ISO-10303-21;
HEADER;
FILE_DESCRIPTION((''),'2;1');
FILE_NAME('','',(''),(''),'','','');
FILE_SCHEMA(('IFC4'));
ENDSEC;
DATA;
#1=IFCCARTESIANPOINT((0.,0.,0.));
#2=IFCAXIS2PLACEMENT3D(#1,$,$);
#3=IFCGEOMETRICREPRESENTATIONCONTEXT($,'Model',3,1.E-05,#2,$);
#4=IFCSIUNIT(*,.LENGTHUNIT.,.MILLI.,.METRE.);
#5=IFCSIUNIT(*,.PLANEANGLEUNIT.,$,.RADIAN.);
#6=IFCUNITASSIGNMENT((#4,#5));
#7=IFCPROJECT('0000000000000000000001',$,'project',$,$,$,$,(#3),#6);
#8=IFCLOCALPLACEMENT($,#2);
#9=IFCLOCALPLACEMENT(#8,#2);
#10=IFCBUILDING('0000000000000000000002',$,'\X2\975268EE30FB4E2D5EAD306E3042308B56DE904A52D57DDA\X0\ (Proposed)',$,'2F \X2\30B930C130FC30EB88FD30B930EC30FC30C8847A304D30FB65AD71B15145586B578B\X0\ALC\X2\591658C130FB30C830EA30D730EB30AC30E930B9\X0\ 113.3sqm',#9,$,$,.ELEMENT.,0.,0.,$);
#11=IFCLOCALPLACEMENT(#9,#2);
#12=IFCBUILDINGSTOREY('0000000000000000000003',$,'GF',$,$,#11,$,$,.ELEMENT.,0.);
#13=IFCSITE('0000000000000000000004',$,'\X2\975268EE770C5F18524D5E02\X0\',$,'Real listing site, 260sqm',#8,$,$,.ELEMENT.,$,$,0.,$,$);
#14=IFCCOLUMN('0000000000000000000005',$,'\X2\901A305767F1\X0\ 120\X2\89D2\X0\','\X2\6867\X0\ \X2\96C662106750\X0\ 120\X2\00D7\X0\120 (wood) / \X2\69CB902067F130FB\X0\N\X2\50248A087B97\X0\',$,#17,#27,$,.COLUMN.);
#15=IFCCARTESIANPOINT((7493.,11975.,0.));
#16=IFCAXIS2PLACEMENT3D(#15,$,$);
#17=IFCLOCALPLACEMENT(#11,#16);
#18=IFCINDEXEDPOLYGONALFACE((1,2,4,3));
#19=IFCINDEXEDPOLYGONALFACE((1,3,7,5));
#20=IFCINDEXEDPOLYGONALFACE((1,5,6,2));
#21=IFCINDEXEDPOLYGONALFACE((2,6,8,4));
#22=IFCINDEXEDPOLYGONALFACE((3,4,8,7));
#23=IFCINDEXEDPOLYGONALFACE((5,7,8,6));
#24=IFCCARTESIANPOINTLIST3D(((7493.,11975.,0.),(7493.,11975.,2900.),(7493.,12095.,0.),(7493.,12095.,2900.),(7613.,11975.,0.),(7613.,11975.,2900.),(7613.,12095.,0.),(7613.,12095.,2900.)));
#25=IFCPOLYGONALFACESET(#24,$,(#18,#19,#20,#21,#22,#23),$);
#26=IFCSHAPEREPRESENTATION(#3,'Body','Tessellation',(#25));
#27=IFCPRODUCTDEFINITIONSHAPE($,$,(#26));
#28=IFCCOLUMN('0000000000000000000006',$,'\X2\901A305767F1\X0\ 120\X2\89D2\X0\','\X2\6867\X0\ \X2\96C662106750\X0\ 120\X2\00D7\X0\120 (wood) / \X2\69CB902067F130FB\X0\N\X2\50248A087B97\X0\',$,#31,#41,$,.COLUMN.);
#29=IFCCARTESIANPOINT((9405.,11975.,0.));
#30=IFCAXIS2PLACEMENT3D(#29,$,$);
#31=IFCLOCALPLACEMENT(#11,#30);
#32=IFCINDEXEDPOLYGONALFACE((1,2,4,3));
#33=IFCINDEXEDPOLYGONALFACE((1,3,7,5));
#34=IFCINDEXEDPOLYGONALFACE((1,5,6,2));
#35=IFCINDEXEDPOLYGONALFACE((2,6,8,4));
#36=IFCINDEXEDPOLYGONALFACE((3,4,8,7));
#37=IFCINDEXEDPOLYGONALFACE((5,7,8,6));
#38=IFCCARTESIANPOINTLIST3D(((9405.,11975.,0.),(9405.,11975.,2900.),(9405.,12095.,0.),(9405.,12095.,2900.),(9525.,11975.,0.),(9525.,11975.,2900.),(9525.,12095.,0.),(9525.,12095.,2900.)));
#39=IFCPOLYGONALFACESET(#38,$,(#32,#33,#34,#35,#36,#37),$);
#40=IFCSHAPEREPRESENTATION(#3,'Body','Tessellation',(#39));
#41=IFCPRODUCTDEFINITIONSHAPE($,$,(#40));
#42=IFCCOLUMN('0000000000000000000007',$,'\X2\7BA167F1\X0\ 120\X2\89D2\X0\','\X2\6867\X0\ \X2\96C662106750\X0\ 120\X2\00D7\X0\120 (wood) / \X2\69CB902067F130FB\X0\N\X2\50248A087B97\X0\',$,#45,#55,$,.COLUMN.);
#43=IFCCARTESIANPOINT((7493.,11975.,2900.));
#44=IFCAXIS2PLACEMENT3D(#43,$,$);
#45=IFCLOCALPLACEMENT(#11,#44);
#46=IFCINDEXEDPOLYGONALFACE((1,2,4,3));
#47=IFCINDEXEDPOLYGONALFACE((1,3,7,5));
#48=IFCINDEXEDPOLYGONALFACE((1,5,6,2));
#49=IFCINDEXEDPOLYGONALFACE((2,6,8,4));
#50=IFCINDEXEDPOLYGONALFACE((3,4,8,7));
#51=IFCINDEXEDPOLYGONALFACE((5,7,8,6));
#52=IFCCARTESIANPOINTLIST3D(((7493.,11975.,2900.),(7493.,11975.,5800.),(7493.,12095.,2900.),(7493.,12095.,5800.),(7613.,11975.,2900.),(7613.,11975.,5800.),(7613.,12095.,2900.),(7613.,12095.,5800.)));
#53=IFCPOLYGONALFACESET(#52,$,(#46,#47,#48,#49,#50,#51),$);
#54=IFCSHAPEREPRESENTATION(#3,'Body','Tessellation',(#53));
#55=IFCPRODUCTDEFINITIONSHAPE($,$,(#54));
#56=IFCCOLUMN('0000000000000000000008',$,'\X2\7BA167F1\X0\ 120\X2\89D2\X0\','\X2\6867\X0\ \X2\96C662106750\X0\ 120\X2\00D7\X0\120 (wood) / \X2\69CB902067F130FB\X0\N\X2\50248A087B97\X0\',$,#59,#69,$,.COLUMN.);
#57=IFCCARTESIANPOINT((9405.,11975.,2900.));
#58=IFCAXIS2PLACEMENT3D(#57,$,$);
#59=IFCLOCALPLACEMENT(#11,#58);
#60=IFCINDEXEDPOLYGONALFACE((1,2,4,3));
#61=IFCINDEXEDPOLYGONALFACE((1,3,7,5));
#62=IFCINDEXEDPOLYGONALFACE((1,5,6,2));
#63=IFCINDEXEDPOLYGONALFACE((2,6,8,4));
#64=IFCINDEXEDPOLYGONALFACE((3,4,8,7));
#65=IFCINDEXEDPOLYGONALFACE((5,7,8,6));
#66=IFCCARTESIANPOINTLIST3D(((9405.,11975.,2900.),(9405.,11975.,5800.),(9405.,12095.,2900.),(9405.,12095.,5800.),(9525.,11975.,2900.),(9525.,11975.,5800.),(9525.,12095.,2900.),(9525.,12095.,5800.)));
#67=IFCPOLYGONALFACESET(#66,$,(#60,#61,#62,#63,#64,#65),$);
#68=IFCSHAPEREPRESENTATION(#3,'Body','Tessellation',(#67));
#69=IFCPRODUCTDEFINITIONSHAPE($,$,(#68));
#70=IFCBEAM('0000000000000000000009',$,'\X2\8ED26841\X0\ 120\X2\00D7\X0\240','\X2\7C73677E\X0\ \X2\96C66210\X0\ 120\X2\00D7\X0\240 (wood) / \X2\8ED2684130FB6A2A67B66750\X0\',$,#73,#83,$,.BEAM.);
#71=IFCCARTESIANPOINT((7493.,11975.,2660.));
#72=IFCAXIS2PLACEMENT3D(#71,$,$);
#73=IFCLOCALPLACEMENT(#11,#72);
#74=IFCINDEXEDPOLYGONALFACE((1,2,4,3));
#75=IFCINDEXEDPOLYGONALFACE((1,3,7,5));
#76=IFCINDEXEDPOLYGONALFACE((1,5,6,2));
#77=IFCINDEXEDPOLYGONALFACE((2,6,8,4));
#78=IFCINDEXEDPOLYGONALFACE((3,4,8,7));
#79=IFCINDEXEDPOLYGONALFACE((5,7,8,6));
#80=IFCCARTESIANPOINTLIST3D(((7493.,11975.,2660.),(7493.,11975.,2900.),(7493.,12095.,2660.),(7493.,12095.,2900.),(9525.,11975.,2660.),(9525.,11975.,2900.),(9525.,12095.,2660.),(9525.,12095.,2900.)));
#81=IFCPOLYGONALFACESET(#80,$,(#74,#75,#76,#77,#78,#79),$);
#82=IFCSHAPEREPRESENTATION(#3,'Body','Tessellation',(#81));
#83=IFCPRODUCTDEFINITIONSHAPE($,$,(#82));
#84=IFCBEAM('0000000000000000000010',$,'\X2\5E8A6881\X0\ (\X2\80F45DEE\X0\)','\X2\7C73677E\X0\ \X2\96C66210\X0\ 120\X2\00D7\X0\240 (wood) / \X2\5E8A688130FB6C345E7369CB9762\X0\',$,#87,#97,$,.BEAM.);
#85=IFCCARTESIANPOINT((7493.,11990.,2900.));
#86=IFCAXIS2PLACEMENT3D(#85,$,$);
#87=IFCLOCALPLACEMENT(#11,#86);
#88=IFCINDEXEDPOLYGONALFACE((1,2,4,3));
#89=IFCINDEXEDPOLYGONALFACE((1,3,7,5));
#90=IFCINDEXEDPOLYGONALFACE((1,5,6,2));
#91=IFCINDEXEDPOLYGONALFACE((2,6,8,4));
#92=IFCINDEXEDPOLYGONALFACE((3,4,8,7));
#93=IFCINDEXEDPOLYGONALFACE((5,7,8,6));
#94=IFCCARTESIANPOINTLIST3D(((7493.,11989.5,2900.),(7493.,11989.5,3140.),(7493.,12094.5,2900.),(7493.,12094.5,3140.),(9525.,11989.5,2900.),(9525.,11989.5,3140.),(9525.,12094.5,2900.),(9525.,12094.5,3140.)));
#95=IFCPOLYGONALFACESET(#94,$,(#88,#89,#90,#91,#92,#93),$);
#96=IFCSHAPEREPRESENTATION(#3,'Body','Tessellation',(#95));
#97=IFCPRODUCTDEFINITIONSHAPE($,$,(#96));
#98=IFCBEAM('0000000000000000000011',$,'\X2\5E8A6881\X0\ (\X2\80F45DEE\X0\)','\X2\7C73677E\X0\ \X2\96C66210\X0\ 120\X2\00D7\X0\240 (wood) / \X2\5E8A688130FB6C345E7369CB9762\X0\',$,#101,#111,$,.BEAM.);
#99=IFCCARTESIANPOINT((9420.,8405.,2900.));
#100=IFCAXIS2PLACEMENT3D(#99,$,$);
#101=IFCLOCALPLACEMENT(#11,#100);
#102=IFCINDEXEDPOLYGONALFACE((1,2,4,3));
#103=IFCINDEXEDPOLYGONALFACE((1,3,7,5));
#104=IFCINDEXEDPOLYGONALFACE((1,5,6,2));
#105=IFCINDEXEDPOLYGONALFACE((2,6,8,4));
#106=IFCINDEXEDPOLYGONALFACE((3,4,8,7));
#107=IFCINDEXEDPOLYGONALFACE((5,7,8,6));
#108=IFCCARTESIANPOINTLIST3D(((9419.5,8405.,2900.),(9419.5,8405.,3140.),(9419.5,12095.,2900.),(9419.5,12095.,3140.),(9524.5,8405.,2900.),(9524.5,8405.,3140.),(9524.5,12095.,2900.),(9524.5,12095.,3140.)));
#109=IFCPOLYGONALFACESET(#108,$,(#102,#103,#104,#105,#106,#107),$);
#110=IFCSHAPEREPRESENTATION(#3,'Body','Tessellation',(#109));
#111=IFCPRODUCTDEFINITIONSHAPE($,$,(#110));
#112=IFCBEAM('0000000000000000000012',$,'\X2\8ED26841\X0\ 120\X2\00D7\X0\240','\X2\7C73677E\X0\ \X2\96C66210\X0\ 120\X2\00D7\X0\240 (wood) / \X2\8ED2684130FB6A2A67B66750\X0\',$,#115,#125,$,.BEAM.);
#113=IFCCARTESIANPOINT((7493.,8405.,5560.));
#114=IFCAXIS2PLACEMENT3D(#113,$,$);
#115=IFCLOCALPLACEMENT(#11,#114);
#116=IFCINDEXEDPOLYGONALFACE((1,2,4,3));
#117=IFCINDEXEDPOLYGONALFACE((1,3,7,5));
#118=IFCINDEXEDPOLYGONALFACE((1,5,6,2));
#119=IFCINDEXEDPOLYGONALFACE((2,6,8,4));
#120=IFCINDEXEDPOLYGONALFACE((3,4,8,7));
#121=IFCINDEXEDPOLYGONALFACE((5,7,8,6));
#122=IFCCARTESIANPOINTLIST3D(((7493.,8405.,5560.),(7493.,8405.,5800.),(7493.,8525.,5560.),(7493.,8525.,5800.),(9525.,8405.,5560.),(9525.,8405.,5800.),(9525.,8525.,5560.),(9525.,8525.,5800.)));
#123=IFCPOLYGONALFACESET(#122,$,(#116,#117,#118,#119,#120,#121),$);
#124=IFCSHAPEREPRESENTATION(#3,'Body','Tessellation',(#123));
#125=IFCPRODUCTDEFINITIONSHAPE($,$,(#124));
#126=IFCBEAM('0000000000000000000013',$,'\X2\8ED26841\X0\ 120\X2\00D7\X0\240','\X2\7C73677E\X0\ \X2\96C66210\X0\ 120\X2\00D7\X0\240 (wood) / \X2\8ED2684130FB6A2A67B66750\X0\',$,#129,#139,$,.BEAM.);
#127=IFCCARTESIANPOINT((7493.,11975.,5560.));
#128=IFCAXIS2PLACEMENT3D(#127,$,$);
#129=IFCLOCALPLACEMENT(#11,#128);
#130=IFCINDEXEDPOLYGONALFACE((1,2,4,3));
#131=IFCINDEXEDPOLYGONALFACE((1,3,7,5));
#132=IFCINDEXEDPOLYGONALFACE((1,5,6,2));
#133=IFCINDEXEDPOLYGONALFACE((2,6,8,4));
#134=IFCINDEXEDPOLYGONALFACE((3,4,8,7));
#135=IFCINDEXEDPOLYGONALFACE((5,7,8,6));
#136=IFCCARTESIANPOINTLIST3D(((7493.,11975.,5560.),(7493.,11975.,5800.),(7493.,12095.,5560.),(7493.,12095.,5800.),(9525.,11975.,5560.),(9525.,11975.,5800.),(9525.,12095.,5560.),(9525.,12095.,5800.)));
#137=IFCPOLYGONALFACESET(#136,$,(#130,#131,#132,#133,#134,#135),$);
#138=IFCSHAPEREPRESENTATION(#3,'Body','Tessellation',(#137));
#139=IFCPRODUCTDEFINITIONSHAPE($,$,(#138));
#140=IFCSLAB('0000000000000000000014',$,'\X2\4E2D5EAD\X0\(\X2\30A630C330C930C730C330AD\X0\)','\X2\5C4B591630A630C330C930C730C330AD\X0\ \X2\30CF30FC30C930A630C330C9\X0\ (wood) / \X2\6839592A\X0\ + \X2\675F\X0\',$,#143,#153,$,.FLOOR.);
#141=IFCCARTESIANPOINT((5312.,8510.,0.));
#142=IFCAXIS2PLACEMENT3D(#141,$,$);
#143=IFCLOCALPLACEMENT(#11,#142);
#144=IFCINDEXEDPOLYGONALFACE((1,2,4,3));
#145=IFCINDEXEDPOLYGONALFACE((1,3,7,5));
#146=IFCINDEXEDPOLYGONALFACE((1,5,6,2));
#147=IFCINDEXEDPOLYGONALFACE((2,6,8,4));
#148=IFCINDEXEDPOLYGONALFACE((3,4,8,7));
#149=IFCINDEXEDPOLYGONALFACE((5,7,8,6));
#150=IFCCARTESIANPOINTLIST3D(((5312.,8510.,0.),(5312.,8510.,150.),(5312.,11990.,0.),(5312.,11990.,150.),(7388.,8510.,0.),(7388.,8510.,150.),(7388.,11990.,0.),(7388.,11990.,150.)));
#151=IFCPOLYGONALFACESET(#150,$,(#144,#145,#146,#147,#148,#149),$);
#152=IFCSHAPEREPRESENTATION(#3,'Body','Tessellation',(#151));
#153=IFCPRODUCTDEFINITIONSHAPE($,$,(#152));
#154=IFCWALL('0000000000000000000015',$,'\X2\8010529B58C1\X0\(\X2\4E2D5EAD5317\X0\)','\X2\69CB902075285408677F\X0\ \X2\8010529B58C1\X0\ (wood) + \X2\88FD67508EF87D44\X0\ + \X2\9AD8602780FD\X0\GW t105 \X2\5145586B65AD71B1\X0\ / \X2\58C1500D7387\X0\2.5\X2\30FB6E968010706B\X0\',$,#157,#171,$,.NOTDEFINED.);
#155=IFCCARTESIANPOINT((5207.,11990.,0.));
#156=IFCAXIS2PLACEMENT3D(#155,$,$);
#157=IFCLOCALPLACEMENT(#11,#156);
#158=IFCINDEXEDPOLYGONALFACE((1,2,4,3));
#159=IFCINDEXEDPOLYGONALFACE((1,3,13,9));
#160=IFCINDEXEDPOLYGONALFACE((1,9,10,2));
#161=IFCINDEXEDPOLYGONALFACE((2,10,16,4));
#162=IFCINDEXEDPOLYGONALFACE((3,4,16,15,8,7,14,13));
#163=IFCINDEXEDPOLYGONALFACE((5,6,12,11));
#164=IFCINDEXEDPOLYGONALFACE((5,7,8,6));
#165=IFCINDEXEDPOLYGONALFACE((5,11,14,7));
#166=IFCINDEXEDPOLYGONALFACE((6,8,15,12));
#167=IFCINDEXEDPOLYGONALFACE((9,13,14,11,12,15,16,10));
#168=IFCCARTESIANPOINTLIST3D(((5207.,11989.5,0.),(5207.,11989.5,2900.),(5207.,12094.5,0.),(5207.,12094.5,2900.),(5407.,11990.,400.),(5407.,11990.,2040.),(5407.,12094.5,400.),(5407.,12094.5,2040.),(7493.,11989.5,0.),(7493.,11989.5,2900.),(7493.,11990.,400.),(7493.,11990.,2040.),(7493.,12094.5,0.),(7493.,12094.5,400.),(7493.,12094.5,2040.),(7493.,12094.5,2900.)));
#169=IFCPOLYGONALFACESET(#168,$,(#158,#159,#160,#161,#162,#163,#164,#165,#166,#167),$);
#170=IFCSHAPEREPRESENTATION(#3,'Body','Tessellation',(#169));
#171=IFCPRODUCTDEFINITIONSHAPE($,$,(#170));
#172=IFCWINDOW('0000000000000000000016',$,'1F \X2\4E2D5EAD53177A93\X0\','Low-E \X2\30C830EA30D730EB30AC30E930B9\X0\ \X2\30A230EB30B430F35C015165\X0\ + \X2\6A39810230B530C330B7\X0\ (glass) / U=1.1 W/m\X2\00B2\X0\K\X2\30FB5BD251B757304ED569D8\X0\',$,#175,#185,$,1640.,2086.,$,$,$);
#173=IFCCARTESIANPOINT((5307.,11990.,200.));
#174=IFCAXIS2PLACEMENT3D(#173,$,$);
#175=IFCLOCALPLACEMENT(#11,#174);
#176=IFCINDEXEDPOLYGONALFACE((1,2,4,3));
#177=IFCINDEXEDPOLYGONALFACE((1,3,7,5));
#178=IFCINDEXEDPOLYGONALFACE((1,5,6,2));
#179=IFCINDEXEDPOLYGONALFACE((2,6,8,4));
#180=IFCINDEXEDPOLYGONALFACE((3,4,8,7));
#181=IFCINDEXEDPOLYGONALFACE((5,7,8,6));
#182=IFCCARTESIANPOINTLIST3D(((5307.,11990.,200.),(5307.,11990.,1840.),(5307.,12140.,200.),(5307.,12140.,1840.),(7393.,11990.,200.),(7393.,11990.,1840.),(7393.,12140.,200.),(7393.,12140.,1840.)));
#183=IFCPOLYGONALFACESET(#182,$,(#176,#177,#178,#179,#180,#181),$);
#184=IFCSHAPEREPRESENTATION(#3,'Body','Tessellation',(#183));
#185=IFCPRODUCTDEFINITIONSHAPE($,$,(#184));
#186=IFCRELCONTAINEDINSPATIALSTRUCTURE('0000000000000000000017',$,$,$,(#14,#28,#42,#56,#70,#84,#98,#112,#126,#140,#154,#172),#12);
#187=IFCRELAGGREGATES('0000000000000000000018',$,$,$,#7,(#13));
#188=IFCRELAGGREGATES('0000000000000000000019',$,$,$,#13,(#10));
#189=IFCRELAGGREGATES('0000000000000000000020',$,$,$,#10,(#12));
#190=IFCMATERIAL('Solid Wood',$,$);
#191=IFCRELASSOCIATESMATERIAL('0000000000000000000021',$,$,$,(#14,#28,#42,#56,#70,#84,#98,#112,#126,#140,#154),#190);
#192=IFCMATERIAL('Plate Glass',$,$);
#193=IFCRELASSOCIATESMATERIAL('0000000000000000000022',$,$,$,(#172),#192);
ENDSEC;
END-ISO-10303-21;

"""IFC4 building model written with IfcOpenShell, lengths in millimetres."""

from ifc_helpers import new_model, si_unit, frame, frame_2d, origin, place, context, project, spatial, rectangle, extrude, material, element, fill, save


model = new_model("IFC4")

# Units and contexts
model_context = context("Model", 3, precision=1e-05, world=origin())
ifc_project = project(units=[si_unit("LENGTHUNIT", "METRE", prefix="MILLI"), si_unit("PLANEANGLEUNIT", "RADIAN")], contexts=[model_context])

# Site, building, storey
site_placement = place(None, origin())
site = spatial("IfcSite", under=ifc_project, at=site_placement, Name="青森県弘前市", ObjectType="Real listing site, 260sqm", CompositionType="ELEMENT", RefElevation=0.0)
building_placement = place(site_placement, origin())
building = spatial("IfcBuilding", under=site, at=building_placement, Name="青森・中庭のある回遊動線 (Proposed)", ObjectType="2F スチール製スレート葺き・断熱充填型ALC外壁・トリプルガラス 113.3sqm", CompositionType="ELEMENT", ElevationOfRefHeight=0.0, ElevationOfTerrain=0.0)
storey_placement = place(building_placement, origin())
storey = spatial("IfcBuildingStorey", under=building, at=storey_placement, Name="GF", CompositionType="ELEMENT", Elevation=0.0)

# Columns
ifc_material_1 = material(Name="Solid Wood")
column_1_placement = place(storey_placement, frame((7493.0, 11975.0, 0.0)))
element("IfcColumn", 1, at=column_1_placement, inside=storey, material=ifc_material_1, Name="通し柱 120角", Description="桧 集成材 120×120 (wood) / 構造柱・N値計算", PredefinedType="COLUMN", context=model_context, shape_type="SweptSolid", body=[
    extrude(rectangle(XDim=120.0, YDim=120.0, at=frame_2d((60.0, 60.0))), frame((7493.0, 11975.0, 0.0)), (0.0, 0.0, 1.0), 2900.0),
])
column_2_placement = place(storey_placement, frame((9405.0, 11975.0, 0.0)))
element("IfcColumn", 2, at=column_2_placement, inside=storey, material=ifc_material_1, Name="通し柱 120角", Description="桧 集成材 120×120 (wood) / 構造柱・N値計算", PredefinedType="COLUMN", context=model_context, shape_type="SweptSolid", body=[
    extrude(rectangle(XDim=120.0, YDim=120.0, at=frame_2d((60.0, 60.0))), frame((9405.0, 11975.0, 0.0)), (0.0, 0.0, 1.0), 2900.0),
])
column_3_placement = place(storey_placement, frame((7493.0, 11975.0, 2900.0)))
element("IfcColumn", 3, at=column_3_placement, inside=storey, material=ifc_material_1, Name="管柱 120角", Description="桧 集成材 120×120 (wood) / 構造柱・N値計算", PredefinedType="COLUMN", context=model_context, shape_type="SweptSolid", body=[
    extrude(rectangle(XDim=120.0, YDim=120.0, at=frame_2d((60.0, 60.0))), frame((7493.0, 11975.0, 2900.0)), (0.0, 0.0, 1.0), 2900.0),
])
column_4_placement = place(storey_placement, frame((9405.0, 11975.0, 2900.0)))
element("IfcColumn", 4, at=column_4_placement, inside=storey, material=ifc_material_1, Name="管柱 120角", Description="桧 集成材 120×120 (wood) / 構造柱・N値計算", PredefinedType="COLUMN", context=model_context, shape_type="SweptSolid", body=[
    extrude(rectangle(XDim=120.0, YDim=120.0, at=frame_2d((60.0, 60.0))), frame((9405.0, 11975.0, 2900.0)), (0.0, 0.0, 1.0), 2900.0),
])

# Beams
beam_1_placement = place(storey_placement, frame((7493.0, 11975.0, 2660.0)))
element("IfcBeam", 5, at=beam_1_placement, inside=storey, material=ifc_material_1, Name="軒桁 120×240", Description="米松 集成 120×240 (wood) / 軒桁・横架材", PredefinedType="BEAM", context=model_context, shape_type="SweptSolid", body=[
    extrude(rectangle(XDim=2032.0, YDim=120.0, at=frame_2d((1016.0, 60.0))), frame((7493.0, 11975.0, 2660.0)), (0.0, 0.0, 1.0), 240.0),
])
beam_2_placement = place(storey_placement, frame((7493.0, 11990.0, 2900.0)))
element("IfcBeam", 6, at=beam_2_placement, inside=storey, material=ifc_material_1, Name="床梁 (胴差)", Description="米松 集成 120×240 (wood) / 床梁・水平構面", PredefinedType="BEAM", context=model_context, shape_type="SweptSolid", body=[
    extrude(rectangle(XDim=2032.0, YDim=105.0, at=frame_2d((1016.0, 52.0))), frame((7493.0, 11990.0, 2900.0)), (0.0, 0.0, 1.0), 240.0),
])
beam_3_placement = place(storey_placement, frame((9420.0, 8405.0, 2900.0)))
element("IfcBeam", 7, at=beam_3_placement, inside=storey, material=ifc_material_1, Name="床梁 (胴差)", Description="米松 集成 120×240 (wood) / 床梁・水平構面", PredefinedType="BEAM", context=model_context, shape_type="SweptSolid", body=[
    extrude(rectangle(XDim=105.0, YDim=3690.0, at=frame_2d((52.0, 1845.0))), frame((9420.0, 8405.0, 2900.0)), (0.0, 0.0, 1.0), 240.0),
])
beam_4_placement = place(storey_placement, frame((7493.0, 8405.0, 5560.0)))
element("IfcBeam", 8, at=beam_4_placement, inside=storey, material=ifc_material_1, Name="軒桁 120×240", Description="米松 集成 120×240 (wood) / 軒桁・横架材", PredefinedType="BEAM", context=model_context, shape_type="SweptSolid", body=[
    extrude(rectangle(XDim=2032.0, YDim=120.0, at=frame_2d((1016.0, 60.0))), frame((7493.0, 8405.0, 5560.0)), (0.0, 0.0, 1.0), 240.0),
])
beam_5_placement = place(storey_placement, frame((7493.0, 11975.0, 5560.0)))
element("IfcBeam", 9, at=beam_5_placement, inside=storey, material=ifc_material_1, Name="軒桁 120×240", Description="米松 集成 120×240 (wood) / 軒桁・横架材", PredefinedType="BEAM", context=model_context, shape_type="SweptSolid", body=[
    extrude(rectangle(XDim=2032.0, YDim=120.0, at=frame_2d((1016.0, 60.0))), frame((7493.0, 11975.0, 5560.0)), (0.0, 0.0, 1.0), 240.0),
])

# Slab
slab_placement = place(storey_placement, frame((5312.0, 8510.0, 0.0)))
element("IfcSlab", 10, at=slab_placement, inside=storey, material=ifc_material_1, Name="中庭(ウッドデッキ)", Description="屋外ウッドデッキ ハードウッド (wood) / 根太 + 束", PredefinedType="FLOOR", context=model_context, shape_type="SweptSolid", body=[
    extrude(rectangle(XDim=2076.0, YDim=3480.0, at=frame_2d((1038.0, 1740.0))), frame((5312.0, 8510.0, 0.0)), (0.0, 0.0, 1.0), 150.0),
])

# Wall, opening, window
wall_1_placement = place(storey_placement, frame((5207.0, 11990.0, 0.0)))
wall_1 = element("IfcWall", 11, at=wall_1_placement, inside=storey, material=ifc_material_1, Name="耐力壁(中庭北)", Description="構造用合板 耐力壁 (wood) + 製材軸組 + 高性能GW t105 充填断熱 / 壁倍率2.5・準耐火", PredefinedType="NOTDEFINED", context=model_context, shape_type="SweptSolid", body=[
    extrude(rectangle(XDim=2286.0, YDim=105.0, at=frame_2d((1143.0, 52.0))), frame((5207.0, 11990.0, 0.0)), (0.0, 0.0, 1.0), 2900.0),
])
opening_1_placement = place(storey_placement, frame((5307.0, 11990.0, 200.0)))
opening_1 = element("IfcOpeningElement", 12, at=opening_1_placement, cuts=wall_1, PredefinedType="NOTDEFINED", context=model_context, shape_type="SweptSolid", body=[
    extrude(rectangle(XDim=2086.0, YDim=150.0, at=frame_2d((1043.0, 75.0))), frame((5307.0, 11990.0, 200.0)), (0.0, 0.0, 1.0), 1640.0),
])
ifc_material_2 = material(Name="Plate Glass")
window_1_placement = place(storey_placement, frame((5307.0, 11990.0, 200.0)))
window_1 = element("IfcWindow", 13, at=window_1_placement, inside=storey, material=ifc_material_2, Name="1F 中庭北窓", Description="Low-E トリプルガラス アルゴン封入 + 樹脂サッシ (glass) / U=1.1 W/m²K・寒冷地仕様", OverallHeight=1640.0, OverallWidth=2086.0, context=model_context, shape_type="SweptSolid", body=[
    extrude(rectangle(XDim=2086.0, YDim=150.0, at=frame_2d((1043.0, 75.0))), frame((5307.0, 11990.0, 200.0)), (0.0, 0.0, 1.0), 1640.0),
])
fill(opening_1, window_1)

save(model, "model.ifc")
